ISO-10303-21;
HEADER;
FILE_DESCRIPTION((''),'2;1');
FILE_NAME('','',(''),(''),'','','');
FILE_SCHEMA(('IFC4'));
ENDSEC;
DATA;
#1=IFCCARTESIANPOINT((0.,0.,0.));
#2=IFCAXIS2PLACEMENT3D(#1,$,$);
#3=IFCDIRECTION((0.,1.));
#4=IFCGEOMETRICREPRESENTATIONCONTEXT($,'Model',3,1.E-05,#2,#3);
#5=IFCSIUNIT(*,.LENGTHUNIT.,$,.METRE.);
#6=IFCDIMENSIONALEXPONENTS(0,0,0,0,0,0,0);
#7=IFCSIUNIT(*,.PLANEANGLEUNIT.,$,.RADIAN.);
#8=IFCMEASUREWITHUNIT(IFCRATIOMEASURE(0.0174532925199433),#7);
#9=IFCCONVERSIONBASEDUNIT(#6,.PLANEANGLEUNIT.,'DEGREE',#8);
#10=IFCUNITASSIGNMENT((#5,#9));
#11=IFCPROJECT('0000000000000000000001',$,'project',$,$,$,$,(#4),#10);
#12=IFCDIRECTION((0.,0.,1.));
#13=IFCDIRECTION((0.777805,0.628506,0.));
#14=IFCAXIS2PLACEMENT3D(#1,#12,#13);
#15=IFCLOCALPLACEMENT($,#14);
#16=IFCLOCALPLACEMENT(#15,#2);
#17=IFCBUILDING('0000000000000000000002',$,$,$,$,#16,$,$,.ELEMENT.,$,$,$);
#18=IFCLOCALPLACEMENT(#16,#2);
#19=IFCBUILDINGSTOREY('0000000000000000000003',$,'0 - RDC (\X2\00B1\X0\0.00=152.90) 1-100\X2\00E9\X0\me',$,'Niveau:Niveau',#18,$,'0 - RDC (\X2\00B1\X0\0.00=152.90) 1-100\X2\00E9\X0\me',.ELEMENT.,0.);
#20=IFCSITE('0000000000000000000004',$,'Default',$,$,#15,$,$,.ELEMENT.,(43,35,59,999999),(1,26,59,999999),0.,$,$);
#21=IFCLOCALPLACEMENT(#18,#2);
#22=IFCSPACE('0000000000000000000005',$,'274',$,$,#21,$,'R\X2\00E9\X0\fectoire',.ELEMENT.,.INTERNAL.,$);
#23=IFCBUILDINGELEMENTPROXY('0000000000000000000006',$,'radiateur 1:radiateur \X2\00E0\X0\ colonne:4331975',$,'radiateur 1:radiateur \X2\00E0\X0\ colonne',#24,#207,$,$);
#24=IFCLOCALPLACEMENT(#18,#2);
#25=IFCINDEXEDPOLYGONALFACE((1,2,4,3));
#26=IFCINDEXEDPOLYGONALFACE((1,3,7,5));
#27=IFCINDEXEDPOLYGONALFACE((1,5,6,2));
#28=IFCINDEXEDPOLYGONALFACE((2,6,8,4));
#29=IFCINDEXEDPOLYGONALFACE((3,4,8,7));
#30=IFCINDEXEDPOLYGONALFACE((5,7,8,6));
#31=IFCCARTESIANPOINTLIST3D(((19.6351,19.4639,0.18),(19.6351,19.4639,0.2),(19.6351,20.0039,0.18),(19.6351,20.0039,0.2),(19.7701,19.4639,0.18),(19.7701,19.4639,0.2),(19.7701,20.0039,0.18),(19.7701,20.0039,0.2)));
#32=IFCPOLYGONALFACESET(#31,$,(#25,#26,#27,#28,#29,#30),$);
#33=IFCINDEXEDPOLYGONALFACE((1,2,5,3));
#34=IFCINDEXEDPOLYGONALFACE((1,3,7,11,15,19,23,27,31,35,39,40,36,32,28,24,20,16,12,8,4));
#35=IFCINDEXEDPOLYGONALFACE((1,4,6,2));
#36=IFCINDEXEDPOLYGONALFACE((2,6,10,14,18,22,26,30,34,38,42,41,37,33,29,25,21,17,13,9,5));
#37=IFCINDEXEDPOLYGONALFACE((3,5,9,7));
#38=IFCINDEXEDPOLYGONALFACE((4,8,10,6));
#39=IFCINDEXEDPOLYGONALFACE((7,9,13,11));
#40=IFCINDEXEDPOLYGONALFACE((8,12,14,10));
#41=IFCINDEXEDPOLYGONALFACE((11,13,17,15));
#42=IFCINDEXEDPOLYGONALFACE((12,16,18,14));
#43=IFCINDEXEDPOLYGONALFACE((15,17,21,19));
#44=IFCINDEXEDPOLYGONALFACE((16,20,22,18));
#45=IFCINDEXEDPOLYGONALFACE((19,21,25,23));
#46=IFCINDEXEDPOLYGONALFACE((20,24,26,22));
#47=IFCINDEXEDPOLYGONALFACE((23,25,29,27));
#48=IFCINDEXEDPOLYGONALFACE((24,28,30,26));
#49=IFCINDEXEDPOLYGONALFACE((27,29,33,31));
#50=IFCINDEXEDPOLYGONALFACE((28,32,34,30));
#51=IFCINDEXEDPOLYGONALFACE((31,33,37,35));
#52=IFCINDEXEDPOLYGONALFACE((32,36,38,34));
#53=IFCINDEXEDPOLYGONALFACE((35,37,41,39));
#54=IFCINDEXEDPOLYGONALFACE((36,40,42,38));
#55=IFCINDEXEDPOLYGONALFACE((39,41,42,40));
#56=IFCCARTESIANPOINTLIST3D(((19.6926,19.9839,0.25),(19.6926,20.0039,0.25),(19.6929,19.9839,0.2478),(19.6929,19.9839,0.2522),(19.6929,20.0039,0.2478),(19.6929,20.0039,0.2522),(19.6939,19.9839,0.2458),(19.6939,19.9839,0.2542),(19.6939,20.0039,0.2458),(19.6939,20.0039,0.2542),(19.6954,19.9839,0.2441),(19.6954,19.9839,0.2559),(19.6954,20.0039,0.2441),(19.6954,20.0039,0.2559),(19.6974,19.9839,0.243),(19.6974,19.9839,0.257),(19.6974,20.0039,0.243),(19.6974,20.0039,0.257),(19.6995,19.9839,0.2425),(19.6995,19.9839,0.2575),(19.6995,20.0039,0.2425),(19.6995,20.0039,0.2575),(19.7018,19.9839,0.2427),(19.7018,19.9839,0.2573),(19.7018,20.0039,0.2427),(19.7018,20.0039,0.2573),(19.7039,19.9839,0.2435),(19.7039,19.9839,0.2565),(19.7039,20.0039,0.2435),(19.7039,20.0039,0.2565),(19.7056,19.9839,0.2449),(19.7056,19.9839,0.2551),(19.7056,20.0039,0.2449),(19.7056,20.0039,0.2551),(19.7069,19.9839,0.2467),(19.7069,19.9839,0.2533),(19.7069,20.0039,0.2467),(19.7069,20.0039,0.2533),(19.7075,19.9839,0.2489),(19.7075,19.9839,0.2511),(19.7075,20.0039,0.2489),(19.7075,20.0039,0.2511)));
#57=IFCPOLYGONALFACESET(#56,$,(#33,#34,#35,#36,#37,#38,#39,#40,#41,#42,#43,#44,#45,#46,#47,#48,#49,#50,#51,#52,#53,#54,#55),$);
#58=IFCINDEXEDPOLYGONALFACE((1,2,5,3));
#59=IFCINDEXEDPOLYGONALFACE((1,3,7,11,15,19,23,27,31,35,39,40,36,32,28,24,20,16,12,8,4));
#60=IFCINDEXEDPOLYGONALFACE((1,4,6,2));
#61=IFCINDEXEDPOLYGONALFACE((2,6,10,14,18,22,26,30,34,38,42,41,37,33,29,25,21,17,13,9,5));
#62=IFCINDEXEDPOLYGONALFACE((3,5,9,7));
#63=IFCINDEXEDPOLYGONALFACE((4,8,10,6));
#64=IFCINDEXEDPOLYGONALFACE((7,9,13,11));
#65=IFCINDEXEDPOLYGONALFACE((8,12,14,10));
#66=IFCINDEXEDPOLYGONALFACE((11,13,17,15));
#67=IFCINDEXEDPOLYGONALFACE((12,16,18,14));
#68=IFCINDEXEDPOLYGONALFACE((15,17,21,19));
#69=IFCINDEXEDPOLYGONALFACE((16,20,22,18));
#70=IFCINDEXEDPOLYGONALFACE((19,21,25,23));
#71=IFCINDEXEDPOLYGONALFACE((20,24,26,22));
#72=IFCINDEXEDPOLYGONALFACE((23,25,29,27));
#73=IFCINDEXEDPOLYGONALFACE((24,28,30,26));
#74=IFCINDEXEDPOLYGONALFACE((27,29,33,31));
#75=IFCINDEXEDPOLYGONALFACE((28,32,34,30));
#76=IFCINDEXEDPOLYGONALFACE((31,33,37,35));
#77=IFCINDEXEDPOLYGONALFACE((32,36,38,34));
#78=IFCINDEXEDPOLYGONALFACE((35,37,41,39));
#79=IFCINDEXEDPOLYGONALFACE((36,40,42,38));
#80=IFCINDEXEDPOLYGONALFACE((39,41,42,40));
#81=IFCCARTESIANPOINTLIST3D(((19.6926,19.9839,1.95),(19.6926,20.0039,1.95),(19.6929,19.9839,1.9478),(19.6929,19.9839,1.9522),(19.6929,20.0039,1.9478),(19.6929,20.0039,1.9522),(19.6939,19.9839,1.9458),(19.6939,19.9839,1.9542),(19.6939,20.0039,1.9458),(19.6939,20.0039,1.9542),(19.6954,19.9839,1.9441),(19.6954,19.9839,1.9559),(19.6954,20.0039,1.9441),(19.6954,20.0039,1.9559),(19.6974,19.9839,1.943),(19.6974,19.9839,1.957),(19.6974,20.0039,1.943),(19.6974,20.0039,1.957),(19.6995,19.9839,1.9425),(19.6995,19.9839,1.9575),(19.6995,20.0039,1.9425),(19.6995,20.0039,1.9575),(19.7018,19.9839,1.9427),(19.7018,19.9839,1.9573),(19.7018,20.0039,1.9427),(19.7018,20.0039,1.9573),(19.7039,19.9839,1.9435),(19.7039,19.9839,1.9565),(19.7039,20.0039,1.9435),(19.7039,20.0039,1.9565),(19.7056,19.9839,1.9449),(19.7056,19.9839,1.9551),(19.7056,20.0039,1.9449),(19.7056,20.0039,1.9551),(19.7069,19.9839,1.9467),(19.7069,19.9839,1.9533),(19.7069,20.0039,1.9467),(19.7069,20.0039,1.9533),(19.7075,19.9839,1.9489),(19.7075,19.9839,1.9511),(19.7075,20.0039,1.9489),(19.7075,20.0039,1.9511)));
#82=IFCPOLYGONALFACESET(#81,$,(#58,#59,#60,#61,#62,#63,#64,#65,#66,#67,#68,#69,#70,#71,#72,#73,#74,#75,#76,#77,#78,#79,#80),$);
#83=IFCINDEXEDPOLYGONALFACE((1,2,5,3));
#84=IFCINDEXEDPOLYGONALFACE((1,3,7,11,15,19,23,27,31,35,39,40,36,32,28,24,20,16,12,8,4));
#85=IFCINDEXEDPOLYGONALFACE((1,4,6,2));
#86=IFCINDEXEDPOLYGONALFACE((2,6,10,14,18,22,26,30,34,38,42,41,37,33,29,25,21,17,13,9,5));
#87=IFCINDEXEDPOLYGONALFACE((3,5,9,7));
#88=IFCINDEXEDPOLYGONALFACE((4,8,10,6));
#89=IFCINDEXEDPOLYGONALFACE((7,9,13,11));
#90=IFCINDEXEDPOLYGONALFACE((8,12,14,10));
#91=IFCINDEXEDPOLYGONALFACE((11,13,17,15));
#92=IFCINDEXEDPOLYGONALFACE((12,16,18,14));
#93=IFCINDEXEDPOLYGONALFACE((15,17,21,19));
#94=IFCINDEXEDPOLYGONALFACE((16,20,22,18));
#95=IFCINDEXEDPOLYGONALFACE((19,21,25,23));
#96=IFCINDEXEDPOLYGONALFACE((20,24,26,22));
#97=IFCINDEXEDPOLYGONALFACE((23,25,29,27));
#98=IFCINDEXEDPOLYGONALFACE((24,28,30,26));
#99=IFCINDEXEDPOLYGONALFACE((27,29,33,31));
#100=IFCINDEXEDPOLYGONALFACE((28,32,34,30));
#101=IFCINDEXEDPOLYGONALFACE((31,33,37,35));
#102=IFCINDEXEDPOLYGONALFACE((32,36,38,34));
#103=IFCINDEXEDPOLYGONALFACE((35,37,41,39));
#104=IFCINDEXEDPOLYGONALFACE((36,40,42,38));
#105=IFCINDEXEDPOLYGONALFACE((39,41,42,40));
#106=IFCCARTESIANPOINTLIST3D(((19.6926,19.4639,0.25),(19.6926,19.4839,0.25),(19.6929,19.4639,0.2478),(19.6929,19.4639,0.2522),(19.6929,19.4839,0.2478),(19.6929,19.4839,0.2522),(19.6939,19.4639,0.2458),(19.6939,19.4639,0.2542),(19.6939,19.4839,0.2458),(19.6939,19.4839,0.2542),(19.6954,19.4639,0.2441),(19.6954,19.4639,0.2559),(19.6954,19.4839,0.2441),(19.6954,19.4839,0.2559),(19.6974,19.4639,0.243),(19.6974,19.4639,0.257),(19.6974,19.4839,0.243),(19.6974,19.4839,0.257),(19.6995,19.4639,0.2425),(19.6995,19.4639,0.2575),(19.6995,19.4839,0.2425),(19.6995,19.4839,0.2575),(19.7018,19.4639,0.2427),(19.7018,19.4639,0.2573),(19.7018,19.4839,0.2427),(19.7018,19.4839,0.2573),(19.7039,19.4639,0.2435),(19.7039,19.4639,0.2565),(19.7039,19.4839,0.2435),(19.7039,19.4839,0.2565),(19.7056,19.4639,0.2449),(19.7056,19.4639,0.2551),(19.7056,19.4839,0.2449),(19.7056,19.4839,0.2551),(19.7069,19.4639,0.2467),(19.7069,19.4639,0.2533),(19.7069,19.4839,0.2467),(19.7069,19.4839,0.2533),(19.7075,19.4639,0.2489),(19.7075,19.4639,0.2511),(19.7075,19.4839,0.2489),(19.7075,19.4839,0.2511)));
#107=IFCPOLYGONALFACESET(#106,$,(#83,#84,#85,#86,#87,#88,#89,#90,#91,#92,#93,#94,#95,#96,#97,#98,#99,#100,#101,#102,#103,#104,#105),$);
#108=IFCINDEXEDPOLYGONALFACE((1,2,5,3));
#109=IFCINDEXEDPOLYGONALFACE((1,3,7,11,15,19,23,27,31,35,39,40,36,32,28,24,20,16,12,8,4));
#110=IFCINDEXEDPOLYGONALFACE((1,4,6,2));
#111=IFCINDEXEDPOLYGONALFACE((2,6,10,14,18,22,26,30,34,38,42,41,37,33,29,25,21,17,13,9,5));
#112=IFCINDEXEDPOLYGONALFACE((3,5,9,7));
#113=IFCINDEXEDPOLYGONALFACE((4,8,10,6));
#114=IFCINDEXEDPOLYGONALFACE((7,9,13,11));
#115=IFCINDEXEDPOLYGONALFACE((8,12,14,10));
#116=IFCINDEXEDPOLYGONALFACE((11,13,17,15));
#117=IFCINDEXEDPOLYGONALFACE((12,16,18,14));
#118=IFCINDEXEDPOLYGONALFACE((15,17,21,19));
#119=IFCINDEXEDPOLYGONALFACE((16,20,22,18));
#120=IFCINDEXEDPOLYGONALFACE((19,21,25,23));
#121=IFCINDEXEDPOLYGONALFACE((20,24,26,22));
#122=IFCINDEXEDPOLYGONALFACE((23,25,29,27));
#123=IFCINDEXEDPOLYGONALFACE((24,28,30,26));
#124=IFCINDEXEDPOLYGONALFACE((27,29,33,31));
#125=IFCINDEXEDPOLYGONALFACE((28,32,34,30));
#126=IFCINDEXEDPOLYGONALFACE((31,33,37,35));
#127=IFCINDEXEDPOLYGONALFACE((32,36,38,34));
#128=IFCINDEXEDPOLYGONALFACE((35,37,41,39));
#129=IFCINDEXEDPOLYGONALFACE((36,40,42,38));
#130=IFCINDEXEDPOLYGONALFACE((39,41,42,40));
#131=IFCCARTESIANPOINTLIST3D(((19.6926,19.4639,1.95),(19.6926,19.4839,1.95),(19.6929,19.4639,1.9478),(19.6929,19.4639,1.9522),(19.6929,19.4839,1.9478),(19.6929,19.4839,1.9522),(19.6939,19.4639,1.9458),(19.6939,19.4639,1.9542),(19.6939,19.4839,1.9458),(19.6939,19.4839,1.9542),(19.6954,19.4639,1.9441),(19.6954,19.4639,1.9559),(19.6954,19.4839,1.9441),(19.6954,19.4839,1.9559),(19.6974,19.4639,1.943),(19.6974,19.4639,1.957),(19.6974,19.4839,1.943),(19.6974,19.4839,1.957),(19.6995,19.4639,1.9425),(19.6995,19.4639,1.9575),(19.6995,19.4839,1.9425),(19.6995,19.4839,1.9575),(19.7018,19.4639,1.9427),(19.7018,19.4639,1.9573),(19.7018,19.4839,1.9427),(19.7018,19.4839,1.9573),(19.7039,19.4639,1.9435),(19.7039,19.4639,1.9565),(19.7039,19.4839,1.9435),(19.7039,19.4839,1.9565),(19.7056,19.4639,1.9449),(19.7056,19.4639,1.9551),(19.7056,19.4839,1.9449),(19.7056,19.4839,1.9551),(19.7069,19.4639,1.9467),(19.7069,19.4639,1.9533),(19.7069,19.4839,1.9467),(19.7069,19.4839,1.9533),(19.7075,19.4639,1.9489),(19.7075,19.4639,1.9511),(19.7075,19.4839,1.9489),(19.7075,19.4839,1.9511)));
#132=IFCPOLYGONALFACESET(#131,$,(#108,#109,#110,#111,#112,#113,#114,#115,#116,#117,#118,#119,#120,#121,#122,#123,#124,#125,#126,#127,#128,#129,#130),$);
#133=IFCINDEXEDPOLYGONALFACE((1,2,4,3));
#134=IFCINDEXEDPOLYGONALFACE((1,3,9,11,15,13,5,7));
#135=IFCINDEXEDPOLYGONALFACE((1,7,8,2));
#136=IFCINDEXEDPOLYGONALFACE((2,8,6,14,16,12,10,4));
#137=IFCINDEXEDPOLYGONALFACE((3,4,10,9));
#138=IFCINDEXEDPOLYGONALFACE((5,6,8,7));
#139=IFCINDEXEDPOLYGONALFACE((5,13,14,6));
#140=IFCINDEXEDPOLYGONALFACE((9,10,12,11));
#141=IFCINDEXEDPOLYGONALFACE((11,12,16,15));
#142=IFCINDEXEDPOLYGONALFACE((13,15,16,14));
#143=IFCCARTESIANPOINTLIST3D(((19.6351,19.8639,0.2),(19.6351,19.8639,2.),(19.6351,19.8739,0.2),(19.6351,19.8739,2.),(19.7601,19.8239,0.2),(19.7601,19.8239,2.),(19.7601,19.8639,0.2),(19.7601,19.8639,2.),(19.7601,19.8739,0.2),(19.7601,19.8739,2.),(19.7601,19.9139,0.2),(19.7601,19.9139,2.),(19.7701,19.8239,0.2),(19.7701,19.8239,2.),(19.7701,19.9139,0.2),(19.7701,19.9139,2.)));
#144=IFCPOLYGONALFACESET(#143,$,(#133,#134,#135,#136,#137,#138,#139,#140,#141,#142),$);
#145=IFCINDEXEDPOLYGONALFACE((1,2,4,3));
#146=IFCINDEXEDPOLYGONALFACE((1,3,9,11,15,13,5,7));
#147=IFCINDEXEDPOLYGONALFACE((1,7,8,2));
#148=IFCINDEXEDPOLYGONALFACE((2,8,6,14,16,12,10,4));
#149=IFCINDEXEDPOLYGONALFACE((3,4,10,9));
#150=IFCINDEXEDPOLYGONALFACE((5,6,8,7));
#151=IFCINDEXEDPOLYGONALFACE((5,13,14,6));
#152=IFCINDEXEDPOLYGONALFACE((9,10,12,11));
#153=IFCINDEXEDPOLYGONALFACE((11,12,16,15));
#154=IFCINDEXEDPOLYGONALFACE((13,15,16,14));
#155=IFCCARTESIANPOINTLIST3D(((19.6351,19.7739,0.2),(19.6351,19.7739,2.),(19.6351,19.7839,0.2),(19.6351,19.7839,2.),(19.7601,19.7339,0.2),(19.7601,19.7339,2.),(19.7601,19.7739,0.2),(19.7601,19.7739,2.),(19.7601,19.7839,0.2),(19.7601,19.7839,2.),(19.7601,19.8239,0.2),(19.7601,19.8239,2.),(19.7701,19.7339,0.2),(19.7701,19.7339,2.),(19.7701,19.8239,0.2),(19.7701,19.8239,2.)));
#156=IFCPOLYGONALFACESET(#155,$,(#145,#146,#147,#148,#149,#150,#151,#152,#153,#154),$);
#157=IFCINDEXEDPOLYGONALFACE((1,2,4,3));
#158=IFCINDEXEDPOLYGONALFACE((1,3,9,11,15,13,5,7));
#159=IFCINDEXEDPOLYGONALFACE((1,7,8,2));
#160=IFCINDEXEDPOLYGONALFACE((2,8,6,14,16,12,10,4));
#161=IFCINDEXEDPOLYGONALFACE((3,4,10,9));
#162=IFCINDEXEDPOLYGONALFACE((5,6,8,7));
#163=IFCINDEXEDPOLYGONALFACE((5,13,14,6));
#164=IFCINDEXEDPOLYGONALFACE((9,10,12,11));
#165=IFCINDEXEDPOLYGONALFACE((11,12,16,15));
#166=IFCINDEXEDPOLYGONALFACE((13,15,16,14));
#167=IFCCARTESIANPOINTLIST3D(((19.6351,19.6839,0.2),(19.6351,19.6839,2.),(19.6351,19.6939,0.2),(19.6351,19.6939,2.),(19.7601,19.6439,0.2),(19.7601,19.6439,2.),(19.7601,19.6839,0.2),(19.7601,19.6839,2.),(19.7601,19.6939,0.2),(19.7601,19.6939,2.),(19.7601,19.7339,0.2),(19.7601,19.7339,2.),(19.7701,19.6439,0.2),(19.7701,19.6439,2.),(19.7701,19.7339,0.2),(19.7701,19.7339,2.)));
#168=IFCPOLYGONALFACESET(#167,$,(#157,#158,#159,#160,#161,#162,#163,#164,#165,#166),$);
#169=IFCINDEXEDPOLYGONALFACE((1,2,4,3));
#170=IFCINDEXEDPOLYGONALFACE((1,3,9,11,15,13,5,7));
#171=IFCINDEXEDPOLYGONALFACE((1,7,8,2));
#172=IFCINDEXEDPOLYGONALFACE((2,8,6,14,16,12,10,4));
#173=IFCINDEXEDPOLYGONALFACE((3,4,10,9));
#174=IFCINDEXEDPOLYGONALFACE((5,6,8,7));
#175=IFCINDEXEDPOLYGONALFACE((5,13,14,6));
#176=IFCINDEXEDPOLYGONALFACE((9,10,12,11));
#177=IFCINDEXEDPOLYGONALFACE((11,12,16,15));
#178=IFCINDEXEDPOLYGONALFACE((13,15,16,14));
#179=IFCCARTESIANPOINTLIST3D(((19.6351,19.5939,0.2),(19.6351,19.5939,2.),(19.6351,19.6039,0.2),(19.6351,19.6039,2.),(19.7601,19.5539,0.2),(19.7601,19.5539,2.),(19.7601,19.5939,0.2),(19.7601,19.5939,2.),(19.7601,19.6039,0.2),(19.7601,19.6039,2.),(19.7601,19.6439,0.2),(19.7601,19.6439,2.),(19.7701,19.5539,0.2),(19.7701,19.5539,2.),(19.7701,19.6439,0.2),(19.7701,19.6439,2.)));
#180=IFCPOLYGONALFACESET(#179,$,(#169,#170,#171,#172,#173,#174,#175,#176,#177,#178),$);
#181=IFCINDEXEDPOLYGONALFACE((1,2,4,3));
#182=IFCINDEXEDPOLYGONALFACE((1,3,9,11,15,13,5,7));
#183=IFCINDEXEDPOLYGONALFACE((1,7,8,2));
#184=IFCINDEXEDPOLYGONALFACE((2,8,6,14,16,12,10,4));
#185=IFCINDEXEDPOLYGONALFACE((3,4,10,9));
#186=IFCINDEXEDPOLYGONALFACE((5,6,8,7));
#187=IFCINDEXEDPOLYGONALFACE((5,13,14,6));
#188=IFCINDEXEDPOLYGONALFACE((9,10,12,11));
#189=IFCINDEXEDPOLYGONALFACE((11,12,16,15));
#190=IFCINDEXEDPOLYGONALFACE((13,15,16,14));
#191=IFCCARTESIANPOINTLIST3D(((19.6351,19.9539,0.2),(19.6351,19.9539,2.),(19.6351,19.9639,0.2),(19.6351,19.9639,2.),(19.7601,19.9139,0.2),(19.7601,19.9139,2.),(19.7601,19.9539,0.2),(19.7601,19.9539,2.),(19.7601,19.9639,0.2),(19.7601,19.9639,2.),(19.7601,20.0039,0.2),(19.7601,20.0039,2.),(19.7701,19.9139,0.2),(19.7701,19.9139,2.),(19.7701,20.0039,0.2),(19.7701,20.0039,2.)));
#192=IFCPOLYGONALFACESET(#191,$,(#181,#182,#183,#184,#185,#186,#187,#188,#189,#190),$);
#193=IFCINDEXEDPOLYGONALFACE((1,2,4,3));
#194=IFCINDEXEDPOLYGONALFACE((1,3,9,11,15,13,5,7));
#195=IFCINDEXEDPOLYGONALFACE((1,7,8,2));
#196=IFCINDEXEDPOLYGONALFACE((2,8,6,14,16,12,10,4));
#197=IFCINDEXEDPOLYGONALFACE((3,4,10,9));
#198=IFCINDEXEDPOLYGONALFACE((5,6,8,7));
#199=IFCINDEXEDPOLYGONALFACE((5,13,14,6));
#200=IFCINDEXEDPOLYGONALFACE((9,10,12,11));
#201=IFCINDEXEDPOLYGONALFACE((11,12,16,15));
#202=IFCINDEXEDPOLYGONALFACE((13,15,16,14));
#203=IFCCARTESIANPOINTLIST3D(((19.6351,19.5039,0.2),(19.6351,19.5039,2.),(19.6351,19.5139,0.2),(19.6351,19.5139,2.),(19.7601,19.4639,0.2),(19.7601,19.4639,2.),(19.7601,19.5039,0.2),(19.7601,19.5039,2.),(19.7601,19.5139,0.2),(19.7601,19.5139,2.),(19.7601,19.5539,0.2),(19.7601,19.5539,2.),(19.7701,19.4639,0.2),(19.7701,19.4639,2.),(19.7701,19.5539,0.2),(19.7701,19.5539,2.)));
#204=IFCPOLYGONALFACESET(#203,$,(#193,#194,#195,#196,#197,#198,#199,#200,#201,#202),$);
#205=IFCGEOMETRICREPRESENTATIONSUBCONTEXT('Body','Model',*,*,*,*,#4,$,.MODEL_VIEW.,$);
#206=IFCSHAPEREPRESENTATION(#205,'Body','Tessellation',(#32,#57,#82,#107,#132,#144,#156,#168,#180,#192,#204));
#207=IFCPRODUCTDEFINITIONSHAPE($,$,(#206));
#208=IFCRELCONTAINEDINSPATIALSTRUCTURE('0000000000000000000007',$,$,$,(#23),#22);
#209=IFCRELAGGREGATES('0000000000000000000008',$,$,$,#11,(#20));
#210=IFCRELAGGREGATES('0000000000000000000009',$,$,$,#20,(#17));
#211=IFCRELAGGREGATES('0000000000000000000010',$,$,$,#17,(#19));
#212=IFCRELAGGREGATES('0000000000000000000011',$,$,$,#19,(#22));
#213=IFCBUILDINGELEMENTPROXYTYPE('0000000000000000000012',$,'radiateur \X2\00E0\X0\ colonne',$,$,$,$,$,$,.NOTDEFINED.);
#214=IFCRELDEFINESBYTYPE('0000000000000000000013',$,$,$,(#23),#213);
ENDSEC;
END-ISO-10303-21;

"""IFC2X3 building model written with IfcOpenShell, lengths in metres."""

from ifc_helpers import new_model, entity, si_unit, converted_unit, direction, frame, frame_2d, origin, origin_2d_with_axis, place, context, subcontext, project, spatial, polyline, rectangle, circle, outline, extrude, source, transform, mapped, type_object, type_shapes, element, save


model = new_model("IFC2X3")

# Units and contexts
model_context = context("Model", 3, precision=1e-05, world=origin(), true_north=direction((0.0, 1.0)))
body_context = subcontext(model_context, "Body", "Model", "MODEL_VIEW")
ifc_project = project(units=[si_unit("LENGTHUNIT", "METRE"), converted_unit("PLANEANGLEUNIT", "DEGREE", entity("IfcRatioMeasure", 0.0174532925199433), si_unit("PLANEANGLEUNIT", "RADIAN"), dimensions=[0, 0, 0, 0, 0, 0, 0])], contexts=[model_context])

# Site, building, storey
site_placement = place(None, frame((0.0, 0.0, 0.0), z_axis=(0.0, 0.0, 1.0), x_axis=(0.777805, 0.628506, 0.0)))
site = spatial("IfcSite", under=ifc_project, at=site_placement, Name="Default", CompositionType="ELEMENT", RefLatitude=(43, 35, 59, 999999), RefLongitude=(1, 26, 59, 999999), RefElevation=0.0)
building_placement = place(site_placement, origin())
building = spatial("IfcBuilding", under=site, at=building_placement, CompositionType="ELEMENT")
storey_placement = place(building_placement, origin())
storey = spatial("IfcBuildingStorey", under=building, at=storey_placement, Name="0 - RDC (±0.00=152.90) 1-100éme", ObjectType="Niveau:Niveau", LongName="0 - RDC (±0.00=152.90) 1-100éme", CompositionType="ELEMENT", Elevation=0.0)

# Shared definitions
space_placement = place(storey_placement, origin())
space = spatial("IfcSpace", under=storey, at=space_placement, Name="274", LongName="Réfectoire", CompositionType="ELEMENT", InteriorOrExteriorSpace="INTERNAL")

# Building element proxy
building_element_proxy_type = type_object("IfcBuildingElementProxyType", Name="radiateur à colonne", PredefinedType="NOTDEFINED")
shared_shape_1 = source(origin(), body_context, "Body", "SweptSolid", [
    extrude(rectangle(XDim=0.135, YDim=0.54, at=frame_2d((0.0, 0.0), x_axis=(1.0, 0.0))), frame((0.27, -0.0025, -0.02), z_axis=(0.0, 0.0, 1.0), x_axis=(0.0, -1.0, 0.0)), (0.0, 0.0, 1.0), 0.02),
    extrude(circle(Radius=0.0075, at=frame_2d((0.0, 0.0), x_axis=(1.0, 0.0))), frame((0.52, 0.0, 0.05), z_axis=(1.0, 0.0, 0.0), x_axis=(0.0, 1.0, 0.0)), (0.0, 0.0, 1.0), 0.02),
    extrude(circle(Radius=0.0075, at=frame_2d((0.0, 0.0), x_axis=(1.0, 0.0))), frame((0.52, 0.0, 1.75), z_axis=(1.0, 0.0, 0.0), x_axis=(0.0, 1.0, 0.0)), (0.0, 0.0, 1.0), 0.02),
    extrude(circle(Radius=0.0075, at=frame_2d((0.0, 0.0), x_axis=(1.0, 0.0))), frame((0.0, 0.0, 0.05), z_axis=(1.0, 0.0, 0.0), x_axis=(0.0, 1.0, 0.0)), (0.0, 0.0, 1.0), 0.02),
    extrude(circle(Radius=0.0075, at=origin_2d_with_axis()), frame((0.0, 0.0, 1.75), z_axis=(1.0, 0.0, 0.0), x_axis=(0.0, 1.0, 0.0)), (0.0, 0.0, 1.0), 0.02),
    extrude(outline(polyline([(-0.005, -0.0963), (0.005, -0.0963), (0.005, 0.0288), (0.045, 0.0288), (0.045, 0.0387), (-0.045, 0.0387), (-0.045, 0.0288), (-0.005, 0.0288), (-0.005, -0.0963)])), frame((0.405, -0.0313, 0.0), z_axis=(0.0, 0.0, 1.0), x_axis=(-1.0, 0.0, 0.0)), (0.0, 0.0, 1.0), 1.8),
    extrude(outline(polyline([(-0.005, -0.0963), (0.005, -0.0963), (0.005, 0.0288), (0.045, 0.0288), (0.045, 0.0387), (-0.045, 0.0387), (-0.045, 0.0288), (-0.005, 0.0288), (-0.005, -0.0963)])), frame((0.315, -0.0313, 0.0), z_axis=(0.0, 0.0, 1.0), x_axis=(-1.0, 0.0, 0.0)), (0.0, 0.0, 1.0), 1.8),
    extrude(outline(polyline([(-0.005, -0.0963), (0.005, -0.0963), (0.005, 0.0288), (0.045, 0.0288), (0.045, 0.0387), (-0.045, 0.0387), (-0.045, 0.0288), (-0.005, 0.0288), (-0.005, -0.0963)])), frame((0.225, -0.0313, 0.0), z_axis=(0.0, 0.0, 1.0), x_axis=(-1.0, 0.0, 0.0)), (0.0, 0.0, 1.0), 1.8),
    extrude(outline(polyline([(-0.005, -0.0963), (0.005, -0.0963), (0.005, 0.0288), (0.045, 0.0288), (0.045, 0.0387), (-0.045, 0.0387), (-0.045, 0.0288), (-0.005, 0.0288), (-0.005, -0.0963)])), frame((0.135, -0.0313, 0.0), z_axis=(0.0, 0.0, 1.0), x_axis=(-1.0, 0.0, 0.0)), (0.0, 0.0, 1.0), 1.8),
    extrude(outline(polyline([(-0.005, -0.0963), (0.005, -0.0963), (0.005, 0.0288), (0.045, 0.0288), (0.045, 0.0387), (-0.045, 0.0387), (-0.045, 0.0288), (-0.005, 0.0288), (-0.005, -0.0963)])), frame((0.495, -0.0313, 0.0), z_axis=(0.0, 0.0, 1.0), x_axis=(-1.0, 0.0, 0.0)), (0.0, 0.0, 1.0), 1.8),
    extrude(outline(polyline([(-0.005, -0.0963), (0.005, -0.0963), (0.005, 0.0288), (0.045, 0.0288), (0.045, 0.0387), (-0.045, 0.0387), (-0.045, 0.0288), (-0.005, 0.0288), (-0.005, -0.0963)])), frame((0.045, -0.0313, 0.0), z_axis=(0.0, 0.0, 1.0), x_axis=(-1.0, 0.0, 0.0)), (0.0, 0.0, 1.0), 1.8),
])
type_shapes(building_element_proxy_type, [shared_shape_1])
proxy_placement = place(space_placement, frame((19.7001, 19.4639, 0.2), z_axis=(0.0, 0.0, 1.0), x_axis=(0.0, 1.0, 0.0)))
element("IfcBuildingElementProxy", 1, at=proxy_placement, inside=space, type_object=building_element_proxy_type, Name="radiateur 1:radiateur à colonne:4331975", ObjectType="radiateur 1:radiateur à colonne", context=body_context, shape_type="MappedRepresentation", body=[
    mapped(shared_shape_1, transform((0.0, 0.0, 0.0), scale=1.0)),
])

save(model, "model.ifc")
